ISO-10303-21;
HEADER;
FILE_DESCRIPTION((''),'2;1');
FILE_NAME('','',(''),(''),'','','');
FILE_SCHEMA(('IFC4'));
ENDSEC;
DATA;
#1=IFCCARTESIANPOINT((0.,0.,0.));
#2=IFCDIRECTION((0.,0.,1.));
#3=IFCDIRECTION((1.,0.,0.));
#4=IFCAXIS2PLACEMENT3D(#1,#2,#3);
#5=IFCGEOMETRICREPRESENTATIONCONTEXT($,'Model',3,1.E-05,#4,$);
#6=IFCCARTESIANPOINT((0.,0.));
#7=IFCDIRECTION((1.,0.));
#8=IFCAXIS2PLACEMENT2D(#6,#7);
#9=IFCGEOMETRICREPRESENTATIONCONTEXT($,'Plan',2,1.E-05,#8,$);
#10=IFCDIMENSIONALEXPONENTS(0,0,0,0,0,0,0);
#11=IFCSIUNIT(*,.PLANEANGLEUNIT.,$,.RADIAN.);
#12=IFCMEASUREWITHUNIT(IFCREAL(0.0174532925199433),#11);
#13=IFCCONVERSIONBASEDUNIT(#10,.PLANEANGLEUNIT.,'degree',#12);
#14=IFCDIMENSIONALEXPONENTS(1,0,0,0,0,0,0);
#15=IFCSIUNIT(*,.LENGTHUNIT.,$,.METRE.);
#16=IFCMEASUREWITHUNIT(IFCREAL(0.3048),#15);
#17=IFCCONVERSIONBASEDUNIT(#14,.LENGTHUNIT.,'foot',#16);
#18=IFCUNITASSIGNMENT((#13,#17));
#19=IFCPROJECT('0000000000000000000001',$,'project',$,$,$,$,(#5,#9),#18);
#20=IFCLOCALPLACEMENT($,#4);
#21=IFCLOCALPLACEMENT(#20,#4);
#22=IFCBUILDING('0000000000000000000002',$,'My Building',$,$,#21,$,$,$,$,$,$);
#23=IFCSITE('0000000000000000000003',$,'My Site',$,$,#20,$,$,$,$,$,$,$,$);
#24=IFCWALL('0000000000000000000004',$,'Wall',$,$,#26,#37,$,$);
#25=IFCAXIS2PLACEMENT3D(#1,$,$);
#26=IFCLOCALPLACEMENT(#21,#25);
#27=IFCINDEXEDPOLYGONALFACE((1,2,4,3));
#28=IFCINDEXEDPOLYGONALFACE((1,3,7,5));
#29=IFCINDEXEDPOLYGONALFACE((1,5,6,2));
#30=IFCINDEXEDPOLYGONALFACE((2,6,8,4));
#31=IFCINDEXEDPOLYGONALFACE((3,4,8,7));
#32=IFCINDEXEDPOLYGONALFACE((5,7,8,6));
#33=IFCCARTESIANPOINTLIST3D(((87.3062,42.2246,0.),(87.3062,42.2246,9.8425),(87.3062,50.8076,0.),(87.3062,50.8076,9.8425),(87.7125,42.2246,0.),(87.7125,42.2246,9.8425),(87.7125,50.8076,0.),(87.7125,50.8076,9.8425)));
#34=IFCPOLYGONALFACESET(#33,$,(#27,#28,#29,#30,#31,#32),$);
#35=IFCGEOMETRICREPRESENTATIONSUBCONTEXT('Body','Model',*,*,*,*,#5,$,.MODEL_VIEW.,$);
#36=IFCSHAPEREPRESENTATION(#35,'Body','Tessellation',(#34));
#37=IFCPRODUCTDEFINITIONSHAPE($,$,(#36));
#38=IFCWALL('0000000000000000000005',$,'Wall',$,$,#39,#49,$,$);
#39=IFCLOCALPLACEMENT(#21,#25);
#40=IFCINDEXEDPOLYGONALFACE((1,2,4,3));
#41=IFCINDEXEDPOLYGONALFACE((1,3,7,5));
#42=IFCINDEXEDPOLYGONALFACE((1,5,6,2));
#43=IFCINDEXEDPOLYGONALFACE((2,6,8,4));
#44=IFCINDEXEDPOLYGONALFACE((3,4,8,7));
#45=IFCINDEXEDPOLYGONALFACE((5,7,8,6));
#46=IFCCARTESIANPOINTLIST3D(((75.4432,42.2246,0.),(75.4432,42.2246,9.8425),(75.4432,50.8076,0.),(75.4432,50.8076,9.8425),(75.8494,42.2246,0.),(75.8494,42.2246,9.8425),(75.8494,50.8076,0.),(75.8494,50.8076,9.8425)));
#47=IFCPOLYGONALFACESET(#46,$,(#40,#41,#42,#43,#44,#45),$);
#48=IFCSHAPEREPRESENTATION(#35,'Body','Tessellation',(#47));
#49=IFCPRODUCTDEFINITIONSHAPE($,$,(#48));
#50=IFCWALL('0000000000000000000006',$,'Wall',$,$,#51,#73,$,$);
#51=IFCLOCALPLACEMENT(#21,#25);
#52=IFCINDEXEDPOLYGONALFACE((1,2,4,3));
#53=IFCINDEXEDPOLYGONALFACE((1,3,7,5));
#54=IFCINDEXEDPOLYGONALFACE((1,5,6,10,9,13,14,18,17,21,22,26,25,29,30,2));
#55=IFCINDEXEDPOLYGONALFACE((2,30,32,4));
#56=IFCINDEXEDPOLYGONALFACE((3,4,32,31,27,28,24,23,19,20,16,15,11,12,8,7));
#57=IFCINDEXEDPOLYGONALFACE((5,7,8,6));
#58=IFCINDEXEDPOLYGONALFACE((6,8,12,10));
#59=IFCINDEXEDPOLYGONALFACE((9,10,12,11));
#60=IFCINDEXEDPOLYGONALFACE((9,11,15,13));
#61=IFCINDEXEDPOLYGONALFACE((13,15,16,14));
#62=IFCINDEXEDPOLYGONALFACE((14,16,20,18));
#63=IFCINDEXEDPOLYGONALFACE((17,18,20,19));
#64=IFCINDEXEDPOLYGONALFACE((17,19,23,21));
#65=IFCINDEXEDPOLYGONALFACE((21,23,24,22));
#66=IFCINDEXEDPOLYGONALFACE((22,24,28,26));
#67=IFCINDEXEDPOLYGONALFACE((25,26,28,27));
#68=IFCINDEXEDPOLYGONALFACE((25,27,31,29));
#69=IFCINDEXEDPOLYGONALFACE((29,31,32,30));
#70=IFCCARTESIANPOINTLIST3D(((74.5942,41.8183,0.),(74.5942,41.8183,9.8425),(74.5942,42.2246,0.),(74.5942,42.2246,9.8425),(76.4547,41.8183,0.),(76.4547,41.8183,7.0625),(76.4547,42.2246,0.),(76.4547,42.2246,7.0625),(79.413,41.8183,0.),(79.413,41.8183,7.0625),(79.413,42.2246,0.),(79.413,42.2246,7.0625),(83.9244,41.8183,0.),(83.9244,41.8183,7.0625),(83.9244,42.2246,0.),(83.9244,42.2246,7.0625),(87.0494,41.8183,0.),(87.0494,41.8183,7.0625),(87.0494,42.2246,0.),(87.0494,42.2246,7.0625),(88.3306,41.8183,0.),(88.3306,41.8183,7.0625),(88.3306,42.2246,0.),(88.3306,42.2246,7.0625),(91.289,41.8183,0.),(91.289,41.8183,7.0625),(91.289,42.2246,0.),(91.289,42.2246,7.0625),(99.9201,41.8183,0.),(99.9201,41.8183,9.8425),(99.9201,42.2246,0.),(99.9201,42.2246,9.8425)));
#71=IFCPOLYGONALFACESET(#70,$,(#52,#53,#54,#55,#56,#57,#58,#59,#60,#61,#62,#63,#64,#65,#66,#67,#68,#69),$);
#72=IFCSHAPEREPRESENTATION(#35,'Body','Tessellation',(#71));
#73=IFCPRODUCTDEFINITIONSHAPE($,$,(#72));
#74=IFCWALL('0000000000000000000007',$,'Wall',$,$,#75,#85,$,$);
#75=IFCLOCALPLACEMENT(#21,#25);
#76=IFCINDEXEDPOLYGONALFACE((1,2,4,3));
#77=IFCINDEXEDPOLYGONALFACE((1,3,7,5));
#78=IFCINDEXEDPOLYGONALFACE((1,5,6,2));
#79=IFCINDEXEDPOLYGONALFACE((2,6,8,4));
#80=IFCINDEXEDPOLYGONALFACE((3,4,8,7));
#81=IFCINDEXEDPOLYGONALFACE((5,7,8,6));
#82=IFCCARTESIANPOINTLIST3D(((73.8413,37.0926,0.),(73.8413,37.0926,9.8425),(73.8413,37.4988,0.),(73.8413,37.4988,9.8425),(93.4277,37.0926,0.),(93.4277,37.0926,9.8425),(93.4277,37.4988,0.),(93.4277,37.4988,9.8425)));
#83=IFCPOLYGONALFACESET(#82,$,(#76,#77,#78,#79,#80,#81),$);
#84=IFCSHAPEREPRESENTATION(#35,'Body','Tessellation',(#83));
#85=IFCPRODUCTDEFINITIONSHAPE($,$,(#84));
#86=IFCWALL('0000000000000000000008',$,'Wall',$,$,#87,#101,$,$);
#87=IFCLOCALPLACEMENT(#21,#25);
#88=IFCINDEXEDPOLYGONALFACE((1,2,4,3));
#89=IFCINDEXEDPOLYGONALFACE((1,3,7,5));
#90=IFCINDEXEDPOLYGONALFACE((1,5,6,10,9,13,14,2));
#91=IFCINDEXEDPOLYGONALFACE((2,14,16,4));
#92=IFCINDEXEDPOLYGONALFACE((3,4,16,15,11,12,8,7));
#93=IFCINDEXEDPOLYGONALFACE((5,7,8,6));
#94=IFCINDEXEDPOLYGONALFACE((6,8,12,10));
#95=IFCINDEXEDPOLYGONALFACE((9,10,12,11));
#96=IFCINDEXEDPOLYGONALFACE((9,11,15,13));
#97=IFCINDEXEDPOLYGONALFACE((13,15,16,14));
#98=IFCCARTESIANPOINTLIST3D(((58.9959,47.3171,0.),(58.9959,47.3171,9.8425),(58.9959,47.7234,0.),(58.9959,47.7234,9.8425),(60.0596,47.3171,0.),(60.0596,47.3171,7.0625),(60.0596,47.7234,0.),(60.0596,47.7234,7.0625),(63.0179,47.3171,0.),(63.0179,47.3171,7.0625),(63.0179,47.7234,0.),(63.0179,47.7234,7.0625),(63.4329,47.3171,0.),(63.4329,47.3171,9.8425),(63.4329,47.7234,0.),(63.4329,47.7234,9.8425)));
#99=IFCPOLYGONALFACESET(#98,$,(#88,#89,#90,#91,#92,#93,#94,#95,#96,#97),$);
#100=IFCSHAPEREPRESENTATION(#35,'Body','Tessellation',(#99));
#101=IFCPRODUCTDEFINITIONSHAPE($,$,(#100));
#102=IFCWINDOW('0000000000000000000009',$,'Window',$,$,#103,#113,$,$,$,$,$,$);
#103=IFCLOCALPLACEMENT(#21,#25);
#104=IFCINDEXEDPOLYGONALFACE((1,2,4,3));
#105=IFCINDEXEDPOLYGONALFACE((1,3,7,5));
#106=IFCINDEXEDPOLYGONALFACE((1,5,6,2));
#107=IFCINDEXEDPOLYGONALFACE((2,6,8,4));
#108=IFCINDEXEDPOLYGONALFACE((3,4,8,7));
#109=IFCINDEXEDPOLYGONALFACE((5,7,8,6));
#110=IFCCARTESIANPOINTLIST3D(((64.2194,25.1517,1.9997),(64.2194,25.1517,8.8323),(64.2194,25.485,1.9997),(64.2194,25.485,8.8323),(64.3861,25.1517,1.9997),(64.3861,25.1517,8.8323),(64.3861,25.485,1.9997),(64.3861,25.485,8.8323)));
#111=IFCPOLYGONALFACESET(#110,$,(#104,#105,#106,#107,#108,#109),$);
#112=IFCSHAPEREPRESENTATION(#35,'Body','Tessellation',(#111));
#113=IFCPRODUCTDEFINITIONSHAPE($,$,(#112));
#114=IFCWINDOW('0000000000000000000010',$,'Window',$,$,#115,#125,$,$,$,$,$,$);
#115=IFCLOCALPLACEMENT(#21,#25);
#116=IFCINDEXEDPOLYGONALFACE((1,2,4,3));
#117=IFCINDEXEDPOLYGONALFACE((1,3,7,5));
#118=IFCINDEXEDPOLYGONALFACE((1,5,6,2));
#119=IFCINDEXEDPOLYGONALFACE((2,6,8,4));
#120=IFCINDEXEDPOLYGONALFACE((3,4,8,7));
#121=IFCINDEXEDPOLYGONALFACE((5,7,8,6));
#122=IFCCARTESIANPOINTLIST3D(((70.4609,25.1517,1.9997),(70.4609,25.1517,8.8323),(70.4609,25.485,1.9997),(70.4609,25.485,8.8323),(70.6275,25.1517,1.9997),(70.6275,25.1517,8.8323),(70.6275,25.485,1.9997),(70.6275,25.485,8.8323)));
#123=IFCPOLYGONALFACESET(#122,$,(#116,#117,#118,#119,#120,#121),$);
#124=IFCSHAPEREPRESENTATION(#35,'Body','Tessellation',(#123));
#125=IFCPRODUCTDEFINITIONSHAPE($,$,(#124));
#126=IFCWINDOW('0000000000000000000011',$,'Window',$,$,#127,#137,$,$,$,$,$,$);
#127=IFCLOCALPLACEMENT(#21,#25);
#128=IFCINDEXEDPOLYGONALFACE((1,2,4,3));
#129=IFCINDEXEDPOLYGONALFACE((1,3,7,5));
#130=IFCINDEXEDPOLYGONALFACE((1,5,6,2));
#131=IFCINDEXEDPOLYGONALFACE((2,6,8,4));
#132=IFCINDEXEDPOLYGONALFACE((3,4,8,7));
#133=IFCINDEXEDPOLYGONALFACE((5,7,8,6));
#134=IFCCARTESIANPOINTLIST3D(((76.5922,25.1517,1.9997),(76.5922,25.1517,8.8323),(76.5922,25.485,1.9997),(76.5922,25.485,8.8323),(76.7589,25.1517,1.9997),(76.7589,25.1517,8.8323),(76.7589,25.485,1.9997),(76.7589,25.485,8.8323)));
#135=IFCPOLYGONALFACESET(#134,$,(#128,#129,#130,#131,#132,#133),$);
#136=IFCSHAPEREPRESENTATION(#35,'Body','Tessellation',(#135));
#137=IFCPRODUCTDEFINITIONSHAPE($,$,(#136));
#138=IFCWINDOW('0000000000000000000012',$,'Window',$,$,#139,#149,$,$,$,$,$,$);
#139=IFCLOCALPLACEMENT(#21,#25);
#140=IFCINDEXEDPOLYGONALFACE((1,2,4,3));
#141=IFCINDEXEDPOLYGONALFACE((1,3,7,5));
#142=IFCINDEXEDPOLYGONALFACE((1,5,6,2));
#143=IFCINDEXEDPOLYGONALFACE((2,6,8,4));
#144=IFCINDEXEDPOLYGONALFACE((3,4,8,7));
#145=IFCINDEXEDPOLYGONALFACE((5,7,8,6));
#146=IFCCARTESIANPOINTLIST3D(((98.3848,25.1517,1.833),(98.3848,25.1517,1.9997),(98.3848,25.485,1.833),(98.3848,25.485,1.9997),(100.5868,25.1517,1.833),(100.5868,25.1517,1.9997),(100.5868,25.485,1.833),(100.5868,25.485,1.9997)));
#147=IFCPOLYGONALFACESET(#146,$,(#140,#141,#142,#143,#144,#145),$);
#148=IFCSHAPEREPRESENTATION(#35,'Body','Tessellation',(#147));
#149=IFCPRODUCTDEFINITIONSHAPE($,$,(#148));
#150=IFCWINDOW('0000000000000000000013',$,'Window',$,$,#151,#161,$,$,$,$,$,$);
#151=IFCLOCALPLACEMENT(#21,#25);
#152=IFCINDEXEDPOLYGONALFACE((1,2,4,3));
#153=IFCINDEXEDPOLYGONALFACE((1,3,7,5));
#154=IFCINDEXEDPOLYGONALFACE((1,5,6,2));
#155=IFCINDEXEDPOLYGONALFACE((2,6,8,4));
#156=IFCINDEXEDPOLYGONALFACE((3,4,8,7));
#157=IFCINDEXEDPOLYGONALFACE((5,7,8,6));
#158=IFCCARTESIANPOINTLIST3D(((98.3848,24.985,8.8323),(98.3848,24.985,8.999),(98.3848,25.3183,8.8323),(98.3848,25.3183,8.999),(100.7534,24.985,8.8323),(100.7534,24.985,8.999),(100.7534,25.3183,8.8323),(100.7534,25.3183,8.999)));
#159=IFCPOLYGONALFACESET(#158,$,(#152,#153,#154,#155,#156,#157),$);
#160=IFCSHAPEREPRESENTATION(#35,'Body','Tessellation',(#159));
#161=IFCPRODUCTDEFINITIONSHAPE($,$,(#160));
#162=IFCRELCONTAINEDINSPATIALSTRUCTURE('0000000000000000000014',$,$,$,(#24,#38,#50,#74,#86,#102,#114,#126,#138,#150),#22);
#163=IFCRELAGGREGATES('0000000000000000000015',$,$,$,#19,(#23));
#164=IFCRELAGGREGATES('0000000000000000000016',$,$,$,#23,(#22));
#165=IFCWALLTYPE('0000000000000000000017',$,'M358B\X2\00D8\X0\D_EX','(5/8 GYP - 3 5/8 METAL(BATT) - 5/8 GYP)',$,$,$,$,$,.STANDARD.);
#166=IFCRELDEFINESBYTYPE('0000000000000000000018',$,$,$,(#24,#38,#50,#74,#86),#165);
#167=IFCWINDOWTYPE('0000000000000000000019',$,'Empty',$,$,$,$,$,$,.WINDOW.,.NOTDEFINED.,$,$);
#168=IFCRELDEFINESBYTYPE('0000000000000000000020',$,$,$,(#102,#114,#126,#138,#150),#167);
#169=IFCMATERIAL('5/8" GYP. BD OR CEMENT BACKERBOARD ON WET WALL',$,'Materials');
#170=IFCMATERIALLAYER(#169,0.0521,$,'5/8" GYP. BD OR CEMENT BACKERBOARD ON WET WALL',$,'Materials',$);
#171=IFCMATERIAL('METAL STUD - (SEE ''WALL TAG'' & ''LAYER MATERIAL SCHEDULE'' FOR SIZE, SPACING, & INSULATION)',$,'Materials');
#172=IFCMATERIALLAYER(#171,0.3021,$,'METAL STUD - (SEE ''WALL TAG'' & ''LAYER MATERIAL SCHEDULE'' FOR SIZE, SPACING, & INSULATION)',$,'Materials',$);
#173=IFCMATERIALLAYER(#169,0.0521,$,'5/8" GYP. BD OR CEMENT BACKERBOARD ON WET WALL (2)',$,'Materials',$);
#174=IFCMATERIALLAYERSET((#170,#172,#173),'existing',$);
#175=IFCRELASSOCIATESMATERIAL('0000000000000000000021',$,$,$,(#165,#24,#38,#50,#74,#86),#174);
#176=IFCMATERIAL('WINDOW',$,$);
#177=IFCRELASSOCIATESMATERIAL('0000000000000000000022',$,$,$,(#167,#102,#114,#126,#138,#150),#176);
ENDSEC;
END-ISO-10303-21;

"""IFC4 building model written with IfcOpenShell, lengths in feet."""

from ifc_helpers import new_model, entity, si_unit, converted_unit, frame, origin_with_axes, origin_2d_with_axis, place, context, subcontext, project, spatial, line, indexed_curve, rectangle, outline, extrude, source, transform, mapped, material, layer, layer_set, layer_usage, material_profile, profile_set, profile_usage, type_object, element, save


model = new_model("IFC4")

# Units and contexts
model_context = context("Model", 3, precision=1e-05, world=origin_with_axes())
plan_context = context("Plan", 2, precision=1e-05, world=origin_2d_with_axis())
body_context_1 = subcontext(model_context, "Body", "Model", "MODEL_VIEW")
ifc_project = project(units=[converted_unit("PLANEANGLEUNIT", "degree", entity("IfcReal", 0.0174532925199433), si_unit("PLANEANGLEUNIT", "RADIAN"), dimensions=[0, 0, 0, 0, 0, 0, 0]), converted_unit("LENGTHUNIT", "foot", entity("IfcReal", 0.3048), si_unit("LENGTHUNIT", "METRE"), dimensions=[1, 0, 0, 0, 0, 0, 0])], contexts=[model_context, plan_context])

# Site, building
site_placement = place(None, origin_with_axes())
site = spatial("IfcSite", under=ifc_project, at=site_placement, Name="My Site")
building_placement = place(site_placement, origin_with_axes())
building = spatial("IfcBuilding", under=site, at=building_placement, Name="My Building")

# Shared definitions
ifc_material_1 = material(Name="WINDOW")

# Walls
ifc_material_2 = material(Name="5/8\" GYP. BD OR CEMENT BACKERBOARD ON WET WALL", Category="Materials")
ifc_layer_1 = layer(ifc_material_2, 0.0521, Name="5/8\" GYP. BD OR CEMENT BACKERBOARD ON WET WALL", Category="Materials")
ifc_material_3 = material(Name="METAL STUD - (SEE 'WALL TAG' & 'LAYER MATERIAL SCHEDULE' FOR SIZE, SPACING, & INSULATION)", Category="Materials")
ifc_layer_2 = layer(ifc_material_3, 0.3021, Name="METAL STUD - (SEE 'WALL TAG' & 'LAYER MATERIAL SCHEDULE' FOR SIZE, SPACING, & INSULATION)", Category="Materials")
ifc_layer_3 = layer(ifc_material_2, 0.0521, Name="5/8\" GYP. BD OR CEMENT BACKERBOARD ON WET WALL (2)", Category="Materials")
ifc_layer_set_1 = layer_set([ifc_layer_1, ifc_layer_2, ifc_layer_3], Name="existing")
ifc_layer_usage_1 = layer_usage(ifc_layer_set_1, "AXIS2", "POSITIVE", 0.0)
wall_type_1 = type_object("IfcWallType", Name="M358BØD_EX", Description="(5/8 GYP - 3 5/8 METAL(BATT) - 5/8 GYP)", PredefinedType="STANDARD", material=ifc_layer_set_1)
wall_1_placement = place(building_placement, frame((87.3062, 50.8076, 0.0), z_axis=(0.0, 0.0, 1.0), x_axis=(0.0, -1.0, 0.0)))
element("IfcWall", 1, at=wall_1_placement, inside=building, type_object=wall_type_1, material=ifc_layer_usage_1, Name="Wall", context=body_context_1, shape_type="SweptSolid", body=[
    extrude(outline(indexed_curve([(0.0, 0.0), (0.0, 0.4062), (8.583, 0.4062), (8.583, 0.0), (0.0, 0.0)], self_intersect=False)), origin_with_axes(), (0.0, 0.0, 1.0), 9.8425),
])
ifc_layer_usage_2 = layer_usage(ifc_layer_set_1, "AXIS2", "POSITIVE", 0.0)
wall_2_placement = place(building_placement, frame((75.4432, 50.8076, 0.0), z_axis=(0.0, 0.0, 1.0), x_axis=(0.0, -1.0, 0.0)))
element("IfcWall", 2, at=wall_2_placement, inside=building, type_object=wall_type_1, material=ifc_layer_usage_2, Name="Wall", context=body_context_1, shape_type="SweptSolid", body=[
    extrude(outline(indexed_curve([(0.0, 0.0), (0.0, 0.4062), (8.583, 0.4062), (8.583, 0.0), (0.0, 0.0)], self_intersect=False)), origin_with_axes(), (0.0, 0.0, 1.0), 9.8425),
])

# Wall, openings
ifc_layer_usage_3 = layer_usage(ifc_layer_set_1, "AXIS2", "POSITIVE", 0.0)
wall_3_placement = place(building_placement, frame((99.9201, 42.2246, 0.0), z_axis=(0.0, 0.0, 1.0), x_axis=(-1.0, 0.0, 0.0)))
wall_3 = element("IfcWall", 3, at=wall_3_placement, inside=building, type_object=wall_type_1, material=ifc_layer_usage_3, Name="Wall", context=body_context_1, shape_type="SweptSolid", body=[
    extrude(outline(indexed_curve([(0.0, 0.0), (0.0, 0.4062), (25.3259, 0.4062), (25.3259, 0.0), (0.0, 0.0)], self_intersect=False)), origin_with_axes(), (0.0, 0.0, 1.0), 9.8425),
])
shared_shape_1 = source(origin_with_axes(), body_context_1, "Body", "SweptSolid", [
    extrude(outline(indexed_curve([(0.0, 0.0), (2.9583, 0.0), (2.9583, 7.0625), (0.0, 7.0625)], segments=[line(1, 2), line(2, 3), line(3, 4), line(4, 1)])), frame((0.0, -0.3281, 0.0), z_axis=(0.0, -1.0, 0.0), x_axis=(1.0, 0.0, 0.0)), (0.0, 0.0, -1.0), 1.0624),
])
opening_1_placement = place(wall_3_placement, frame((23.4654, 0.4062, 0.0), z_axis=(0.0, 0.0, 1.0), x_axis=(-1.0, 0.0, 0.0)))
element("IfcOpeningElement", 4, at=opening_1_placement, cuts=wall_3, PredefinedType="OPENING", context=body_context_1, shape_type="MappedRepresentation", body=[
    mapped(shared_shape_1, transform((0.0, 0.0, 0.0), x_axis=(1.0, 0.0, 0.0), y_axis=(0.0, 1.0, 0.0), z_axis=(0.0, 0.0, 1.0), scale=1.0)),
])
opening_2_placement = place(wall_3_placement, frame((11.5895, 0.4062, 0.0), z_axis=(0.0, 0.0, 1.0), x_axis=(-1.0, 0.0, 0.0)))
element("IfcOpeningElement", 5, at=opening_2_placement, cuts=wall_3, PredefinedType="OPENING", context=body_context_1, shape_type="MappedRepresentation", body=[
    mapped(shared_shape_1, transform((0.0, 0.0, 0.0), x_axis=(1.0, 0.0, 0.0), y_axis=(0.0, 1.0, 0.0), z_axis=(0.0, 0.0, 1.0), scale=1.0)),
])
shared_shape_2 = source(origin_with_axes(), body_context_1, "Body", "SweptSolid", [
    extrude(outline(indexed_curve([(0.0, 0.0), (3.125, 0.0), (3.125, 7.0625), (0.0, 7.0625)], segments=[line(1, 2), line(2, 3), line(3, 4), line(4, 1)])), frame((0.0, -0.3281, 0.0), z_axis=(0.0, -1.0, 0.0), x_axis=(1.0, 0.0, 0.0)), (0.0, 0.0, -1.0), 1.0624),
])
opening_3_placement = place(wall_3_placement, frame((15.9957, 0.4062, 0.0), z_axis=(0.0, 0.0, 1.0), x_axis=(-1.0, 0.0, 0.0)))
element("IfcOpeningElement", 6, at=opening_3_placement, cuts=wall_3, PredefinedType="OPENING", context=body_context_1, shape_type="MappedRepresentation", body=[
    mapped(shared_shape_2, transform((0.0, 0.0, 0.0), x_axis=(1.0, 0.0, 0.0), y_axis=(0.0, 1.0, 0.0), z_axis=(0.0, 0.0, 1.0), scale=1.0)),
])

# Wall
ifc_layer_usage_4 = layer_usage(ifc_layer_set_1, "AXIS2", "POSITIVE", 0.0)
wall_4_placement = place(building_placement, frame((93.4277, 37.4988, 0.0), z_axis=(0.0, 0.0, 1.0), x_axis=(-1.0, 0.0, 0.0)))
element("IfcWall", 7, at=wall_4_placement, inside=building, type_object=wall_type_1, material=ifc_layer_usage_4, Name="Wall", context=body_context_1, shape_type="SweptSolid", body=[
    extrude(outline(indexed_curve([(0.0, 0.0), (0.0, 0.4062), (19.5864, 0.4062), (19.5864, 0.0), (0.0, 0.0)], self_intersect=False)), origin_with_axes(), (0.0, 0.0, 1.0), 9.8425),
])

# Wall, opening
ifc_layer_usage_5 = layer_usage(ifc_layer_set_1, "AXIS2", "POSITIVE", 0.0)
wall_5_placement = place(building_placement, frame((63.4329, 47.7234, 0.0), z_axis=(0.0, 0.0, 1.0), x_axis=(-1.0, 0.0, 0.0)))
wall_5 = element("IfcWall", 8, at=wall_5_placement, inside=building, type_object=wall_type_1, material=ifc_layer_usage_5, Name="Wall", context=body_context_1, shape_type="SweptSolid", body=[
    extrude(outline(indexed_curve([(0.0, 0.0), (0.0, 0.4062), (4.437, 0.4062), (4.437, 0.0), (0.0, 0.0)], self_intersect=False)), origin_with_axes(), (0.0, 0.0, 1.0), 9.8425),
])
opening_4_placement = place(wall_5_placement, frame((0.415, 0.0, 0.0), z_axis=(0.0, 0.0, 1.0), x_axis=(1.0, 0.0, 0.0)))
element("IfcOpeningElement", 9, at=opening_4_placement, cuts=wall_5, PredefinedType="OPENING", context=body_context_1, shape_type="MappedRepresentation", body=[
    mapped(shared_shape_1, transform((0.0, 0.0, 0.0), x_axis=(1.0, 0.0, 0.0), y_axis=(0.0, 1.0, 0.0), z_axis=(0.0, 0.0, 1.0), scale=1.0)),
])

# Windows
ifc_material_profile = material_profile(ifc_material_1, rectangle(XDim=0.3333, YDim=0.1667, at=origin_2d_with_axis()))
ifc_profile_set = profile_set([ifc_material_profile], Name="existing")
ifc_profile_usage_1 = profile_usage(ifc_profile_set, cardinal=5)
window_type = type_object("IfcWindowType", Name="Empty", PartitioningType="NOTDEFINED", PredefinedType="WINDOW", material=ifc_profile_set)
window_1_placement = place(building_placement, frame((64.3028, 25.3183, 1.9997), z_axis=(0.0, 0.0, 1.0), x_axis=(0.0, 1.0, 0.0)))
element("IfcWindow", 10, at=window_1_placement, inside=building, type_object=window_type, material=ifc_profile_usage_1, Name="Window", context=body_context_1, shape_type="SweptSolid", body=[
    extrude(rectangle(XDim=0.3333, YDim=0.1667, at=origin_2d_with_axis()), origin_with_axes(), (0.0, 0.0, 1.0), 6.8327),
])
ifc_profile_usage_2 = profile_usage(ifc_profile_set, cardinal=5)
window_2_placement = place(building_placement, frame((70.5442, 25.3183, 1.9997), z_axis=(0.0, 0.0, 1.0), x_axis=(0.0, 1.0, 0.0)))
element("IfcWindow", 11, at=window_2_placement, inside=building, type_object=window_type, material=ifc_profile_usage_2, Name="Window", context=body_context_1, shape_type="SweptSolid", body=[
    extrude(rectangle(XDim=0.3333, YDim=0.1667, at=origin_2d_with_axis()), origin_with_axes(), (0.0, 0.0, 1.0), 6.8327),
])
ifc_profile_usage_3 = profile_usage(ifc_profile_set, cardinal=5)
window_3_placement = place(building_placement, frame((76.6755, 25.3183, 1.9997), z_axis=(0.0, 0.0, 1.0), x_axis=(0.0, 1.0, 0.0)))
element("IfcWindow", 12, at=window_3_placement, inside=building, type_object=window_type, material=ifc_profile_usage_3, Name="Window", context=body_context_1, shape_type="SweptSolid", body=[
    extrude(rectangle(XDim=0.3333, YDim=0.1667, at=origin_2d_with_axis()), origin_with_axes(), (0.0, 0.0, 1.0), 6.8327),
])
ifc_profile_usage_4 = profile_usage(ifc_profile_set, cardinal=5)
window_4_placement = place(building_placement, frame((98.3848, 25.3183, 1.9163), z_axis=(1.0, 0.0, 0.0), x_axis=(0.0, 1.0, 0.0)))
element("IfcWindow", 13, at=window_4_placement, inside=building, type_object=window_type, material=ifc_profile_usage_4, Name="Window", context=body_context_1, shape_type="SweptSolid", body=[
    extrude(rectangle(XDim=0.3333, YDim=0.1667, at=origin_2d_with_axis()), origin_with_axes(), (0.0, 0.0, 1.0), 2.202),
])
ifc_profile_usage_5 = profile_usage(ifc_profile_set, cardinal=5)
window_5_placement = place(building_placement, frame((98.3848, 25.1517, 8.9157), z_axis=(1.0, 0.0, 0.0), x_axis=(0.0, 1.0, 0.0)))
element("IfcWindow", 14, at=window_5_placement, inside=building, type_object=window_type, material=ifc_profile_usage_5, Name="Window", context=body_context_1, shape_type="SweptSolid", body=[
    extrude(rectangle(XDim=0.3333, YDim=0.1667, at=origin_2d_with_axis()), origin_with_axes(), (0.0, 0.0, 1.0), 2.3686),
])

save(model, "model.ifc")
